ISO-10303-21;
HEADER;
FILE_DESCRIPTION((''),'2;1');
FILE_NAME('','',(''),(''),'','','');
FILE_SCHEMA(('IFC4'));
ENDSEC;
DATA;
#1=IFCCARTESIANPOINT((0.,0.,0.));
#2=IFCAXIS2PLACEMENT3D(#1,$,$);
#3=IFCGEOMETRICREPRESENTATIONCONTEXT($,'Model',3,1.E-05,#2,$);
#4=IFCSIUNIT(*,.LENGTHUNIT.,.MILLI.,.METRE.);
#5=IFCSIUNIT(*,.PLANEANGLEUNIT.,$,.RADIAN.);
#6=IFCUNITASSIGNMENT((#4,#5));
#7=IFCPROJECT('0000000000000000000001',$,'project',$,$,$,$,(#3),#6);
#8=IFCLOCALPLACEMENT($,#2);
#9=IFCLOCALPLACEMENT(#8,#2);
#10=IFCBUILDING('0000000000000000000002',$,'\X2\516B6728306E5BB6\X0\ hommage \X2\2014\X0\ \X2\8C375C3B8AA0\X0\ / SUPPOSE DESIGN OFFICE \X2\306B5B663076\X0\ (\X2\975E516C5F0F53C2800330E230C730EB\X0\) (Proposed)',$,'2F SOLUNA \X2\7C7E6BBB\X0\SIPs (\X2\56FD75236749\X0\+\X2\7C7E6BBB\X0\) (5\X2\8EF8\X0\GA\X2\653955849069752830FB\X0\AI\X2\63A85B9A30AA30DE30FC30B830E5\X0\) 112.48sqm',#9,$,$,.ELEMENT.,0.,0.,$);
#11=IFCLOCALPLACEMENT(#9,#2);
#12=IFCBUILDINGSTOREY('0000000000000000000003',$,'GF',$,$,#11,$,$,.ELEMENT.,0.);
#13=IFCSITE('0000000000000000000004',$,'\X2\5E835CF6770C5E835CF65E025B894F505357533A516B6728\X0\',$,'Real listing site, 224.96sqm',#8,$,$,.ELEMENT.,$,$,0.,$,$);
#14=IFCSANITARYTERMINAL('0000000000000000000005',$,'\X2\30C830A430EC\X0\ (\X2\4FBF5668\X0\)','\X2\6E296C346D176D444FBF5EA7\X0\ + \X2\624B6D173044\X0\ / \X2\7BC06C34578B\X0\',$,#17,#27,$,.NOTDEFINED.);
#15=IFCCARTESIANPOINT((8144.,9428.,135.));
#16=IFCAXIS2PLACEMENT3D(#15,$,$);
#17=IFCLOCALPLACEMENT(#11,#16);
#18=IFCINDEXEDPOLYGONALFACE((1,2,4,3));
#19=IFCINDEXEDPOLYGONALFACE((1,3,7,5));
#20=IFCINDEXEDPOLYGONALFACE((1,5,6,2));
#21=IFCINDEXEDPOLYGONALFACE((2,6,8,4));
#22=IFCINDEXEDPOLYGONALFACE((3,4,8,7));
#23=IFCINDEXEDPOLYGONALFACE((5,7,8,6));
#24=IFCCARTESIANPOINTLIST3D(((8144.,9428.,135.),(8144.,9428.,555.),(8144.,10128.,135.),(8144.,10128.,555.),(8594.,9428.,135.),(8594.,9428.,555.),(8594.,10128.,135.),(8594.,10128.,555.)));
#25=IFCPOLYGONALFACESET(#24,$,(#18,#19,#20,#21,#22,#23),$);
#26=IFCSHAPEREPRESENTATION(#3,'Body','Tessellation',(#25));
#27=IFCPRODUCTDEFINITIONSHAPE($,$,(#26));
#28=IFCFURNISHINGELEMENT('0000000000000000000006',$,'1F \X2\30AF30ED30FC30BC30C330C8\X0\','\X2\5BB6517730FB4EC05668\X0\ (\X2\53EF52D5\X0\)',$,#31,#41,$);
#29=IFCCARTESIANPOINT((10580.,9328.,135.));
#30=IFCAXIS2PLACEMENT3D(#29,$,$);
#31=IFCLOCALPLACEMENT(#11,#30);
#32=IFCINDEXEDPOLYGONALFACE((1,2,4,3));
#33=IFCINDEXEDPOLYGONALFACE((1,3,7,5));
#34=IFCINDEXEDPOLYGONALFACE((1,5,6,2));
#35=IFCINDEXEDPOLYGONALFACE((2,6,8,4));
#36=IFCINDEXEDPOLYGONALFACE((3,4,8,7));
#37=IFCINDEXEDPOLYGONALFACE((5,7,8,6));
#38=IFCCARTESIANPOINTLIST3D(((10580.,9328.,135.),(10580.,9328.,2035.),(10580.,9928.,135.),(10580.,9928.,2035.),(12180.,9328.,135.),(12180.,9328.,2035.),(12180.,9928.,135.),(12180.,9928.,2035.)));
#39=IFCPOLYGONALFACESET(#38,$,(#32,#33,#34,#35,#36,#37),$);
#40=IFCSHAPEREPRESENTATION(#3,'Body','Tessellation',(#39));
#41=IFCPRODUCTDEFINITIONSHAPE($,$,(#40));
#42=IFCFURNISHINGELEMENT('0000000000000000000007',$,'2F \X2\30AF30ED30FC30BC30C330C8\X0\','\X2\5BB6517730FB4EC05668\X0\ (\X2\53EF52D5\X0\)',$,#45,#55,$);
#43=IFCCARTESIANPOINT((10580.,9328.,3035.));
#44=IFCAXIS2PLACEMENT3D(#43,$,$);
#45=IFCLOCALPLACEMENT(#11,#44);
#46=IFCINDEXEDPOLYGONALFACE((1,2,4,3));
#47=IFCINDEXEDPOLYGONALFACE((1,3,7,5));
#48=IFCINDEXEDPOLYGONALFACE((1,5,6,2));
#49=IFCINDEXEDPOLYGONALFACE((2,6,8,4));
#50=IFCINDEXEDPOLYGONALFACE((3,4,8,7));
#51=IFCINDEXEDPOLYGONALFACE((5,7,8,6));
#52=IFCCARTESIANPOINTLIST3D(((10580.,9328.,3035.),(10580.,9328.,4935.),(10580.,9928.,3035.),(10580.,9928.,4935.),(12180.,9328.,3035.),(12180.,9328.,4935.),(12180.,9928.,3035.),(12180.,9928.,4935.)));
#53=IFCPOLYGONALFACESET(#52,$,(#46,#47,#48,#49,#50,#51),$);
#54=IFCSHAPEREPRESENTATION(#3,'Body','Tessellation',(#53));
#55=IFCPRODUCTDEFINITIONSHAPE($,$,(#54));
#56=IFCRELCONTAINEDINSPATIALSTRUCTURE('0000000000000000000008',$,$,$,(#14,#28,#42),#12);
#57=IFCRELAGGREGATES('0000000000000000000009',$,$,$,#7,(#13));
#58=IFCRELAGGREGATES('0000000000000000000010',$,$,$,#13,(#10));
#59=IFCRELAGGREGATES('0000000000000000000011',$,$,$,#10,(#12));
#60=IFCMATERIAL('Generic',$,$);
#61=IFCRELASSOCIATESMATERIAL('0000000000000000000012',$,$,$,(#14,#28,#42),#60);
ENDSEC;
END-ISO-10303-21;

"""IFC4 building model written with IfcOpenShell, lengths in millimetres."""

from ifc_helpers import new_model, si_unit, frame, frame_2d, origin, place, context, project, spatial, rectangle, extrude, material, element, save


model = new_model("IFC4")

# Units and contexts
model_context = context("Model", 3, precision=1e-05, world=origin())
ifc_project = project(units=[si_unit("LENGTHUNIT", "METRE", prefix="MILLI"), si_unit("PLANEANGLEUNIT", "RADIAN")], contexts=[model_context])

# Site, building, storey
site_placement = place(None, origin())
site = spatial("IfcSite", under=ifc_project, at=site_placement, Name="広島県広島市安佐南区八木", ObjectType="Real listing site, 224.96sqm", CompositionType="ELEMENT", RefElevation=0.0)
building_placement = place(site_placement, origin())
building = spatial("IfcBuilding", under=site, at=building_placement, Name="八木の家 hommage — 谷尻誠 / SUPPOSE DESIGN OFFICE に学ぶ (非公式参考モデル) (Proposed)", ObjectType="2F SOLUNA 籾殻SIPs (国産杉+籾殻) (5軸GA改善適用・AI推定オマージュ) 112.48sqm", CompositionType="ELEMENT", ElevationOfRefHeight=0.0, ElevationOfTerrain=0.0)
storey_placement = place(building_placement, origin())
storey = spatial("IfcBuildingStorey", under=building, at=storey_placement, Name="GF", CompositionType="ELEMENT", Elevation=0.0)

# Shared definitions
ifc_material_1 = material(Name="Generic")

# Sanitary terminal
sanitary_terminal_1_placement = place(storey_placement, frame((8144.0, 9428.0, 135.0)))
element("IfcSanitaryTerminal", 1, at=sanitary_terminal_1_placement, inside=storey, material=ifc_material_1, Name="トイレ (便器)", Description="温水洗浄便座 + 手洗い / 節水型", PredefinedType="NOTDEFINED", context=model_context, shape_type="SweptSolid", body=[
    extrude(rectangle(XDim=450.0, YDim=700.0, at=frame_2d((225.0, 350.0))), frame((8144.0, 9428.0, 135.0)), (0.0, 0.0, 1.0), 420.0),
])

# Furnishing elements
furnishing_1_placement = place(storey_placement, frame((10580.0, 9328.0, 135.0)))
element("IfcFurnishingElement", 2, at=furnishing_1_placement, inside=storey, material=ifc_material_1, Name="1F クローゼット", Description="家具・什器 (可動)", context=model_context, shape_type="SweptSolid", body=[
    extrude(rectangle(XDim=1600.0, YDim=600.0, at=frame_2d((800.0, 300.0))), frame((10580.0, 9328.0, 135.0)), (0.0, 0.0, 1.0), 1900.0),
])
furnishing_2_placement = place(storey_placement, frame((10580.0, 9328.0, 3035.0)))
element("IfcFurnishingElement", 3, at=furnishing_2_placement, inside=storey, material=ifc_material_1, Name="2F クローゼット", Description="家具・什器 (可動)", context=model_context, shape_type="SweptSolid", body=[
    extrude(rectangle(XDim=1600.0, YDim=600.0, at=frame_2d((800.0, 300.0))), frame((10580.0, 9328.0, 3035.0)), (0.0, 0.0, 1.0), 1900.0),
])

save(model, "model.ifc")
